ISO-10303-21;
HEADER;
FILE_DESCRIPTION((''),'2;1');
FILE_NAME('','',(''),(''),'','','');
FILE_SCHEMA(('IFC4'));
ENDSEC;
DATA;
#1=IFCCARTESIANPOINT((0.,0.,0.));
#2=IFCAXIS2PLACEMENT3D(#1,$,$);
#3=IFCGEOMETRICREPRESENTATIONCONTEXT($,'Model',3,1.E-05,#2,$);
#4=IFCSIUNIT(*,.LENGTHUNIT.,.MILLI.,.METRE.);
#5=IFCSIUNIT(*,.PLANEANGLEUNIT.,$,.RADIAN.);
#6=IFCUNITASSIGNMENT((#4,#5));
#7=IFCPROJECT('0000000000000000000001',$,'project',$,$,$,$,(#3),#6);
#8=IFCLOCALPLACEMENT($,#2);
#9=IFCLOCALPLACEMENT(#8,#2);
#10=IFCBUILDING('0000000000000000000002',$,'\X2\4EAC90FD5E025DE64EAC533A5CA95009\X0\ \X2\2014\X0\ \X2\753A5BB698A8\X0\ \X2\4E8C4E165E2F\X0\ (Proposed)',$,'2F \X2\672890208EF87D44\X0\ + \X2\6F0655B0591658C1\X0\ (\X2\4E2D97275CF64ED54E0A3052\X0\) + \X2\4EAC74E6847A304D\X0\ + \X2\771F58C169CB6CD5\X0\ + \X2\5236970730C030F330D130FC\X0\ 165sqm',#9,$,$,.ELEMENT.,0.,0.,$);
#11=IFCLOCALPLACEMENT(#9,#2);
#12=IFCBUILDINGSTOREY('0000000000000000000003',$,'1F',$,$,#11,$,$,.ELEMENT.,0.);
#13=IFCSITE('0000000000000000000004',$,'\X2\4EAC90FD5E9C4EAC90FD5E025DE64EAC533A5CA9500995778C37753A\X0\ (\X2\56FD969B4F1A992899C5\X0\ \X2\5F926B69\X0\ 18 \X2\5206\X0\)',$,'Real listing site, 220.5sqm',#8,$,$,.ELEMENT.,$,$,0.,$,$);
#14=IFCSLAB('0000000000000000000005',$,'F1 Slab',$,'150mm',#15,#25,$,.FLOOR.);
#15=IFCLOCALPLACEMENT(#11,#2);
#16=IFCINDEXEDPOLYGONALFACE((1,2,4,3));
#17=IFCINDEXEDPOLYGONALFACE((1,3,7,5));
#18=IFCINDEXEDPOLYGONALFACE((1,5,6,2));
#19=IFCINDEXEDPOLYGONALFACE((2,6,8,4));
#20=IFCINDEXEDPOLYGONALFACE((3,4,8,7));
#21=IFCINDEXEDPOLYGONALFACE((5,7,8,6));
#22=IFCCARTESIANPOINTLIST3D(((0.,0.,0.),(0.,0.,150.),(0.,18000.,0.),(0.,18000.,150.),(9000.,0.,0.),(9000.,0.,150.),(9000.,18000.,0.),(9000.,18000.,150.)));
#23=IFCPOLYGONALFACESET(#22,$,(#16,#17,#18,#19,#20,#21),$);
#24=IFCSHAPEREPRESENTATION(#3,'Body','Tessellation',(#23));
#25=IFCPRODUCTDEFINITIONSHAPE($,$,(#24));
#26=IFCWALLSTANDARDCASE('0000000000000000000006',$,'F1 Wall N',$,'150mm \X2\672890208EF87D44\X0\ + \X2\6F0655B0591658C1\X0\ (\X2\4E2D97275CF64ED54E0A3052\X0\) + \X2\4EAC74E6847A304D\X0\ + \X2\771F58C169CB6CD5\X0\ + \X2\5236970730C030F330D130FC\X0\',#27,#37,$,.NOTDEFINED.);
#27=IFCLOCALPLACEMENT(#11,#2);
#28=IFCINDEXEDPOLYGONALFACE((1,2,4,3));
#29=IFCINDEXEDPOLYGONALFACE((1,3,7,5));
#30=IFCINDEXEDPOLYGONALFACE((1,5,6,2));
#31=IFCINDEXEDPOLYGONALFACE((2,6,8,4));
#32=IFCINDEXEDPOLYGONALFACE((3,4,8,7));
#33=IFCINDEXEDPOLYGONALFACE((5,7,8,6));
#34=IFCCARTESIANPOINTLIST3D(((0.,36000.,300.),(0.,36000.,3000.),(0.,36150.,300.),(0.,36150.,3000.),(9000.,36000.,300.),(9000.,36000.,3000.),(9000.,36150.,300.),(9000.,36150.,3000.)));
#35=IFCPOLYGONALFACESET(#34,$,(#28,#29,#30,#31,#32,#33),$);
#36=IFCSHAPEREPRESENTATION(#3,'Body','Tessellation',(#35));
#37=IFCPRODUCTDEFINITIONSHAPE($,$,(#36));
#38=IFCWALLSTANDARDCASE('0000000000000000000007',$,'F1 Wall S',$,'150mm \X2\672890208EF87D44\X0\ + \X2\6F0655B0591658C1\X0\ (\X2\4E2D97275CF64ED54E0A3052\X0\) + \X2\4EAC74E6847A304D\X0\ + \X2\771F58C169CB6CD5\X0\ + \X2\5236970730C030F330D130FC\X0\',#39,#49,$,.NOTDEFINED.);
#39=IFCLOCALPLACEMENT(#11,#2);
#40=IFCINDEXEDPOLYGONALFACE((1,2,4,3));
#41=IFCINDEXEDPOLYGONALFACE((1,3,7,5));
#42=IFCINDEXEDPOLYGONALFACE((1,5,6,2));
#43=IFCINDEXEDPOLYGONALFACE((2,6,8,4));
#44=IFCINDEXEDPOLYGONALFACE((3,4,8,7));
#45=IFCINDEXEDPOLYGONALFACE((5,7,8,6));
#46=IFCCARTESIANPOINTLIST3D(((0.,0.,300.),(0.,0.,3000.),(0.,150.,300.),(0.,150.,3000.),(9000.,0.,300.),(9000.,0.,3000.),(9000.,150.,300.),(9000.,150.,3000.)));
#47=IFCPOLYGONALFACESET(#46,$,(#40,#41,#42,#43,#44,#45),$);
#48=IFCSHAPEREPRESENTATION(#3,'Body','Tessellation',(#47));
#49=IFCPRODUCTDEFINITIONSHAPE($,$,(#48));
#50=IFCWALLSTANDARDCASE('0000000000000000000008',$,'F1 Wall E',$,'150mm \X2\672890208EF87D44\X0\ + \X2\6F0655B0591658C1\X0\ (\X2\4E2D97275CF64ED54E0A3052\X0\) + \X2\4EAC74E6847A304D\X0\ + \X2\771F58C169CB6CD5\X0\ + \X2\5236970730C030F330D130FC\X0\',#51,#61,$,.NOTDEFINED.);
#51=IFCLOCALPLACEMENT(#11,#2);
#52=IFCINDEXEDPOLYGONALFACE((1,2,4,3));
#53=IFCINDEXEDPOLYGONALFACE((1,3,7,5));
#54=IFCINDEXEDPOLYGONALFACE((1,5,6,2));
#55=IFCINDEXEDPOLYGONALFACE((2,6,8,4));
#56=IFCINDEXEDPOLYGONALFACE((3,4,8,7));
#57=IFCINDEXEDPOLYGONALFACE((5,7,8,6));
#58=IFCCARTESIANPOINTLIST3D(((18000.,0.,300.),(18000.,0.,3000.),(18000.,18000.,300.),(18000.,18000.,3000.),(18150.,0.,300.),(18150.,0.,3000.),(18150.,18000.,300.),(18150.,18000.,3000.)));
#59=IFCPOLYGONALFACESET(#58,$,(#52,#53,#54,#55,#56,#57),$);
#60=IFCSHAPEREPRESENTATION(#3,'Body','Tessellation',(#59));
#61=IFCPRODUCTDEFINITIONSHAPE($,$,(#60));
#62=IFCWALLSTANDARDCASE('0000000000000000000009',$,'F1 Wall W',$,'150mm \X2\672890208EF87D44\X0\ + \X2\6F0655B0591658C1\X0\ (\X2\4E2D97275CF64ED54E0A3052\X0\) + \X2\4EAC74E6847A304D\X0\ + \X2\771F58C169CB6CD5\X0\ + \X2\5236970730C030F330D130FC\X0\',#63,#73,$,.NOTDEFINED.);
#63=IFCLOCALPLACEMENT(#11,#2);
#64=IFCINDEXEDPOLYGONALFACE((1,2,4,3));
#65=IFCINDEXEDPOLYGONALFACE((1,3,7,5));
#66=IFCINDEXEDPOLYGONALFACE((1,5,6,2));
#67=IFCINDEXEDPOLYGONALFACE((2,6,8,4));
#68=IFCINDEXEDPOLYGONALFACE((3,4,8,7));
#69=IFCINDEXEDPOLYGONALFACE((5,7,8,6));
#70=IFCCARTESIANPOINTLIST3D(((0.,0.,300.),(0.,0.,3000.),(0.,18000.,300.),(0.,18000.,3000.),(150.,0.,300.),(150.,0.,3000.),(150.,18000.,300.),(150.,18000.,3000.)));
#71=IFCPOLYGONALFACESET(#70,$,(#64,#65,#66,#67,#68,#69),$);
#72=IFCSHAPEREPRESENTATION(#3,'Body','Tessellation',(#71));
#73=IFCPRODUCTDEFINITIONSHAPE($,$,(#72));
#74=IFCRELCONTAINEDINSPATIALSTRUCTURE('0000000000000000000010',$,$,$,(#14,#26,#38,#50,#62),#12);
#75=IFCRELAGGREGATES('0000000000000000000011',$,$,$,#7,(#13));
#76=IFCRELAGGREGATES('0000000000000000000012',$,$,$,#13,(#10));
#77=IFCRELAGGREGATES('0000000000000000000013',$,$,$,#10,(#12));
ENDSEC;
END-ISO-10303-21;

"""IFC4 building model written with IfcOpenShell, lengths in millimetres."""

from ifc_helpers import new_model, si_unit, frame, frame_2d, origin, place, context, project, spatial, rectangle, extrude, element, save


model = new_model("IFC4")

# Units and contexts
model_context = context("Model", 3, precision=1e-05, world=origin())
ifc_project = project(units=[si_unit("LENGTHUNIT", "METRE", prefix="MILLI"), si_unit("PLANEANGLEUNIT", "RADIAN")], contexts=[model_context])

# Site, building, storey
site_placement = place(None, origin())
site = spatial("IfcSite", under=ifc_project, at=site_placement, Name="京都府京都市左京区岩倉長谷町 (国際会館駅 徒歩 18 分)", ObjectType="Real listing site, 220.5sqm", CompositionType="ELEMENT", RefElevation=0.0)
building_placement = place(site_placement, origin())
building = spatial("IfcBuilding", under=site, at=building_placement, Name="京都市左京区岩倉 — 町家風 二世帯 (Proposed)", ObjectType="2F 木造軸組 + 漆喰外壁 (中霧島仕上げ) + 京瓦葺き + 真壁構法 + 制震ダンパー 165sqm", CompositionType="ELEMENT", ElevationOfRefHeight=0.0, ElevationOfTerrain=0.0)
storey_placement = place(building_placement, origin())
storey = spatial("IfcBuildingStorey", under=building, at=storey_placement, Name="1F", CompositionType="ELEMENT", Elevation=0.0)

# Slab
slab_placement = place(storey_placement, origin())
element("IfcSlab", 1, at=slab_placement, inside=storey, Name="F1 Slab", ObjectType="150mm", PredefinedType="FLOOR", context=model_context, shape_type="SweptSolid", body=[
    extrude(rectangle(XDim=9000.0, YDim=18000.0, at=frame_2d((4500.0, 9000.0))), origin(), (0.0, 0.0, 1.0), 150.0),
])

# Walls
wall_1_placement = place(storey_placement, frame((0.0, 18000.0, 150.0)))
element("IfcWallStandardCase", 2, at=wall_1_placement, inside=storey, Name="F1 Wall N", ObjectType="150mm 木造軸組 + 漆喰外壁 (中霧島仕上げ) + 京瓦葺き + 真壁構法 + 制震ダンパー", PredefinedType="NOTDEFINED", context=model_context, shape_type="SweptSolid", body=[
    extrude(rectangle(XDim=9000.0, YDim=150.0, at=frame_2d((4500.0, 75.0))), frame((0.0, 18000.0, 150.0)), (0.0, 0.0, 1.0), 2700.0),
])
wall_2_placement = place(storey_placement, frame((0.0, 0.0, 150.0)))
element("IfcWallStandardCase", 3, at=wall_2_placement, inside=storey, Name="F1 Wall S", ObjectType="150mm 木造軸組 + 漆喰外壁 (中霧島仕上げ) + 京瓦葺き + 真壁構法 + 制震ダンパー", PredefinedType="NOTDEFINED", context=model_context, shape_type="SweptSolid", body=[
    extrude(rectangle(XDim=9000.0, YDim=150.0, at=frame_2d((4500.0, 75.0))), frame((0.0, 0.0, 150.0)), (0.0, 0.0, 1.0), 2700.0),
])
wall_3_placement = place(storey_placement, frame((9000.0, 0.0, 150.0)))
element("IfcWallStandardCase", 4, at=wall_3_placement, inside=storey, Name="F1 Wall E", ObjectType="150mm 木造軸組 + 漆喰外壁 (中霧島仕上げ) + 京瓦葺き + 真壁構法 + 制震ダンパー", PredefinedType="NOTDEFINED", context=model_context, shape_type="SweptSolid", body=[
    extrude(rectangle(XDim=150.0, YDim=18000.0, at=frame_2d((75.0, 9000.0))), frame((9000.0, 0.0, 150.0)), (0.0, 0.0, 1.0), 2700.0),
])
wall_4_placement = place(storey_placement, frame((0.0, 0.0, 150.0)))
element("IfcWallStandardCase", 5, at=wall_4_placement, inside=storey, Name="F1 Wall W", ObjectType="150mm 木造軸組 + 漆喰外壁 (中霧島仕上げ) + 京瓦葺き + 真壁構法 + 制震ダンパー", PredefinedType="NOTDEFINED", context=model_context, shape_type="SweptSolid", body=[
    extrude(rectangle(XDim=150.0, YDim=18000.0, at=frame_2d((75.0, 9000.0))), frame((0.0, 0.0, 150.0)), (0.0, 0.0, 1.0), 2700.0),
])

save(model, "model.ifc")
